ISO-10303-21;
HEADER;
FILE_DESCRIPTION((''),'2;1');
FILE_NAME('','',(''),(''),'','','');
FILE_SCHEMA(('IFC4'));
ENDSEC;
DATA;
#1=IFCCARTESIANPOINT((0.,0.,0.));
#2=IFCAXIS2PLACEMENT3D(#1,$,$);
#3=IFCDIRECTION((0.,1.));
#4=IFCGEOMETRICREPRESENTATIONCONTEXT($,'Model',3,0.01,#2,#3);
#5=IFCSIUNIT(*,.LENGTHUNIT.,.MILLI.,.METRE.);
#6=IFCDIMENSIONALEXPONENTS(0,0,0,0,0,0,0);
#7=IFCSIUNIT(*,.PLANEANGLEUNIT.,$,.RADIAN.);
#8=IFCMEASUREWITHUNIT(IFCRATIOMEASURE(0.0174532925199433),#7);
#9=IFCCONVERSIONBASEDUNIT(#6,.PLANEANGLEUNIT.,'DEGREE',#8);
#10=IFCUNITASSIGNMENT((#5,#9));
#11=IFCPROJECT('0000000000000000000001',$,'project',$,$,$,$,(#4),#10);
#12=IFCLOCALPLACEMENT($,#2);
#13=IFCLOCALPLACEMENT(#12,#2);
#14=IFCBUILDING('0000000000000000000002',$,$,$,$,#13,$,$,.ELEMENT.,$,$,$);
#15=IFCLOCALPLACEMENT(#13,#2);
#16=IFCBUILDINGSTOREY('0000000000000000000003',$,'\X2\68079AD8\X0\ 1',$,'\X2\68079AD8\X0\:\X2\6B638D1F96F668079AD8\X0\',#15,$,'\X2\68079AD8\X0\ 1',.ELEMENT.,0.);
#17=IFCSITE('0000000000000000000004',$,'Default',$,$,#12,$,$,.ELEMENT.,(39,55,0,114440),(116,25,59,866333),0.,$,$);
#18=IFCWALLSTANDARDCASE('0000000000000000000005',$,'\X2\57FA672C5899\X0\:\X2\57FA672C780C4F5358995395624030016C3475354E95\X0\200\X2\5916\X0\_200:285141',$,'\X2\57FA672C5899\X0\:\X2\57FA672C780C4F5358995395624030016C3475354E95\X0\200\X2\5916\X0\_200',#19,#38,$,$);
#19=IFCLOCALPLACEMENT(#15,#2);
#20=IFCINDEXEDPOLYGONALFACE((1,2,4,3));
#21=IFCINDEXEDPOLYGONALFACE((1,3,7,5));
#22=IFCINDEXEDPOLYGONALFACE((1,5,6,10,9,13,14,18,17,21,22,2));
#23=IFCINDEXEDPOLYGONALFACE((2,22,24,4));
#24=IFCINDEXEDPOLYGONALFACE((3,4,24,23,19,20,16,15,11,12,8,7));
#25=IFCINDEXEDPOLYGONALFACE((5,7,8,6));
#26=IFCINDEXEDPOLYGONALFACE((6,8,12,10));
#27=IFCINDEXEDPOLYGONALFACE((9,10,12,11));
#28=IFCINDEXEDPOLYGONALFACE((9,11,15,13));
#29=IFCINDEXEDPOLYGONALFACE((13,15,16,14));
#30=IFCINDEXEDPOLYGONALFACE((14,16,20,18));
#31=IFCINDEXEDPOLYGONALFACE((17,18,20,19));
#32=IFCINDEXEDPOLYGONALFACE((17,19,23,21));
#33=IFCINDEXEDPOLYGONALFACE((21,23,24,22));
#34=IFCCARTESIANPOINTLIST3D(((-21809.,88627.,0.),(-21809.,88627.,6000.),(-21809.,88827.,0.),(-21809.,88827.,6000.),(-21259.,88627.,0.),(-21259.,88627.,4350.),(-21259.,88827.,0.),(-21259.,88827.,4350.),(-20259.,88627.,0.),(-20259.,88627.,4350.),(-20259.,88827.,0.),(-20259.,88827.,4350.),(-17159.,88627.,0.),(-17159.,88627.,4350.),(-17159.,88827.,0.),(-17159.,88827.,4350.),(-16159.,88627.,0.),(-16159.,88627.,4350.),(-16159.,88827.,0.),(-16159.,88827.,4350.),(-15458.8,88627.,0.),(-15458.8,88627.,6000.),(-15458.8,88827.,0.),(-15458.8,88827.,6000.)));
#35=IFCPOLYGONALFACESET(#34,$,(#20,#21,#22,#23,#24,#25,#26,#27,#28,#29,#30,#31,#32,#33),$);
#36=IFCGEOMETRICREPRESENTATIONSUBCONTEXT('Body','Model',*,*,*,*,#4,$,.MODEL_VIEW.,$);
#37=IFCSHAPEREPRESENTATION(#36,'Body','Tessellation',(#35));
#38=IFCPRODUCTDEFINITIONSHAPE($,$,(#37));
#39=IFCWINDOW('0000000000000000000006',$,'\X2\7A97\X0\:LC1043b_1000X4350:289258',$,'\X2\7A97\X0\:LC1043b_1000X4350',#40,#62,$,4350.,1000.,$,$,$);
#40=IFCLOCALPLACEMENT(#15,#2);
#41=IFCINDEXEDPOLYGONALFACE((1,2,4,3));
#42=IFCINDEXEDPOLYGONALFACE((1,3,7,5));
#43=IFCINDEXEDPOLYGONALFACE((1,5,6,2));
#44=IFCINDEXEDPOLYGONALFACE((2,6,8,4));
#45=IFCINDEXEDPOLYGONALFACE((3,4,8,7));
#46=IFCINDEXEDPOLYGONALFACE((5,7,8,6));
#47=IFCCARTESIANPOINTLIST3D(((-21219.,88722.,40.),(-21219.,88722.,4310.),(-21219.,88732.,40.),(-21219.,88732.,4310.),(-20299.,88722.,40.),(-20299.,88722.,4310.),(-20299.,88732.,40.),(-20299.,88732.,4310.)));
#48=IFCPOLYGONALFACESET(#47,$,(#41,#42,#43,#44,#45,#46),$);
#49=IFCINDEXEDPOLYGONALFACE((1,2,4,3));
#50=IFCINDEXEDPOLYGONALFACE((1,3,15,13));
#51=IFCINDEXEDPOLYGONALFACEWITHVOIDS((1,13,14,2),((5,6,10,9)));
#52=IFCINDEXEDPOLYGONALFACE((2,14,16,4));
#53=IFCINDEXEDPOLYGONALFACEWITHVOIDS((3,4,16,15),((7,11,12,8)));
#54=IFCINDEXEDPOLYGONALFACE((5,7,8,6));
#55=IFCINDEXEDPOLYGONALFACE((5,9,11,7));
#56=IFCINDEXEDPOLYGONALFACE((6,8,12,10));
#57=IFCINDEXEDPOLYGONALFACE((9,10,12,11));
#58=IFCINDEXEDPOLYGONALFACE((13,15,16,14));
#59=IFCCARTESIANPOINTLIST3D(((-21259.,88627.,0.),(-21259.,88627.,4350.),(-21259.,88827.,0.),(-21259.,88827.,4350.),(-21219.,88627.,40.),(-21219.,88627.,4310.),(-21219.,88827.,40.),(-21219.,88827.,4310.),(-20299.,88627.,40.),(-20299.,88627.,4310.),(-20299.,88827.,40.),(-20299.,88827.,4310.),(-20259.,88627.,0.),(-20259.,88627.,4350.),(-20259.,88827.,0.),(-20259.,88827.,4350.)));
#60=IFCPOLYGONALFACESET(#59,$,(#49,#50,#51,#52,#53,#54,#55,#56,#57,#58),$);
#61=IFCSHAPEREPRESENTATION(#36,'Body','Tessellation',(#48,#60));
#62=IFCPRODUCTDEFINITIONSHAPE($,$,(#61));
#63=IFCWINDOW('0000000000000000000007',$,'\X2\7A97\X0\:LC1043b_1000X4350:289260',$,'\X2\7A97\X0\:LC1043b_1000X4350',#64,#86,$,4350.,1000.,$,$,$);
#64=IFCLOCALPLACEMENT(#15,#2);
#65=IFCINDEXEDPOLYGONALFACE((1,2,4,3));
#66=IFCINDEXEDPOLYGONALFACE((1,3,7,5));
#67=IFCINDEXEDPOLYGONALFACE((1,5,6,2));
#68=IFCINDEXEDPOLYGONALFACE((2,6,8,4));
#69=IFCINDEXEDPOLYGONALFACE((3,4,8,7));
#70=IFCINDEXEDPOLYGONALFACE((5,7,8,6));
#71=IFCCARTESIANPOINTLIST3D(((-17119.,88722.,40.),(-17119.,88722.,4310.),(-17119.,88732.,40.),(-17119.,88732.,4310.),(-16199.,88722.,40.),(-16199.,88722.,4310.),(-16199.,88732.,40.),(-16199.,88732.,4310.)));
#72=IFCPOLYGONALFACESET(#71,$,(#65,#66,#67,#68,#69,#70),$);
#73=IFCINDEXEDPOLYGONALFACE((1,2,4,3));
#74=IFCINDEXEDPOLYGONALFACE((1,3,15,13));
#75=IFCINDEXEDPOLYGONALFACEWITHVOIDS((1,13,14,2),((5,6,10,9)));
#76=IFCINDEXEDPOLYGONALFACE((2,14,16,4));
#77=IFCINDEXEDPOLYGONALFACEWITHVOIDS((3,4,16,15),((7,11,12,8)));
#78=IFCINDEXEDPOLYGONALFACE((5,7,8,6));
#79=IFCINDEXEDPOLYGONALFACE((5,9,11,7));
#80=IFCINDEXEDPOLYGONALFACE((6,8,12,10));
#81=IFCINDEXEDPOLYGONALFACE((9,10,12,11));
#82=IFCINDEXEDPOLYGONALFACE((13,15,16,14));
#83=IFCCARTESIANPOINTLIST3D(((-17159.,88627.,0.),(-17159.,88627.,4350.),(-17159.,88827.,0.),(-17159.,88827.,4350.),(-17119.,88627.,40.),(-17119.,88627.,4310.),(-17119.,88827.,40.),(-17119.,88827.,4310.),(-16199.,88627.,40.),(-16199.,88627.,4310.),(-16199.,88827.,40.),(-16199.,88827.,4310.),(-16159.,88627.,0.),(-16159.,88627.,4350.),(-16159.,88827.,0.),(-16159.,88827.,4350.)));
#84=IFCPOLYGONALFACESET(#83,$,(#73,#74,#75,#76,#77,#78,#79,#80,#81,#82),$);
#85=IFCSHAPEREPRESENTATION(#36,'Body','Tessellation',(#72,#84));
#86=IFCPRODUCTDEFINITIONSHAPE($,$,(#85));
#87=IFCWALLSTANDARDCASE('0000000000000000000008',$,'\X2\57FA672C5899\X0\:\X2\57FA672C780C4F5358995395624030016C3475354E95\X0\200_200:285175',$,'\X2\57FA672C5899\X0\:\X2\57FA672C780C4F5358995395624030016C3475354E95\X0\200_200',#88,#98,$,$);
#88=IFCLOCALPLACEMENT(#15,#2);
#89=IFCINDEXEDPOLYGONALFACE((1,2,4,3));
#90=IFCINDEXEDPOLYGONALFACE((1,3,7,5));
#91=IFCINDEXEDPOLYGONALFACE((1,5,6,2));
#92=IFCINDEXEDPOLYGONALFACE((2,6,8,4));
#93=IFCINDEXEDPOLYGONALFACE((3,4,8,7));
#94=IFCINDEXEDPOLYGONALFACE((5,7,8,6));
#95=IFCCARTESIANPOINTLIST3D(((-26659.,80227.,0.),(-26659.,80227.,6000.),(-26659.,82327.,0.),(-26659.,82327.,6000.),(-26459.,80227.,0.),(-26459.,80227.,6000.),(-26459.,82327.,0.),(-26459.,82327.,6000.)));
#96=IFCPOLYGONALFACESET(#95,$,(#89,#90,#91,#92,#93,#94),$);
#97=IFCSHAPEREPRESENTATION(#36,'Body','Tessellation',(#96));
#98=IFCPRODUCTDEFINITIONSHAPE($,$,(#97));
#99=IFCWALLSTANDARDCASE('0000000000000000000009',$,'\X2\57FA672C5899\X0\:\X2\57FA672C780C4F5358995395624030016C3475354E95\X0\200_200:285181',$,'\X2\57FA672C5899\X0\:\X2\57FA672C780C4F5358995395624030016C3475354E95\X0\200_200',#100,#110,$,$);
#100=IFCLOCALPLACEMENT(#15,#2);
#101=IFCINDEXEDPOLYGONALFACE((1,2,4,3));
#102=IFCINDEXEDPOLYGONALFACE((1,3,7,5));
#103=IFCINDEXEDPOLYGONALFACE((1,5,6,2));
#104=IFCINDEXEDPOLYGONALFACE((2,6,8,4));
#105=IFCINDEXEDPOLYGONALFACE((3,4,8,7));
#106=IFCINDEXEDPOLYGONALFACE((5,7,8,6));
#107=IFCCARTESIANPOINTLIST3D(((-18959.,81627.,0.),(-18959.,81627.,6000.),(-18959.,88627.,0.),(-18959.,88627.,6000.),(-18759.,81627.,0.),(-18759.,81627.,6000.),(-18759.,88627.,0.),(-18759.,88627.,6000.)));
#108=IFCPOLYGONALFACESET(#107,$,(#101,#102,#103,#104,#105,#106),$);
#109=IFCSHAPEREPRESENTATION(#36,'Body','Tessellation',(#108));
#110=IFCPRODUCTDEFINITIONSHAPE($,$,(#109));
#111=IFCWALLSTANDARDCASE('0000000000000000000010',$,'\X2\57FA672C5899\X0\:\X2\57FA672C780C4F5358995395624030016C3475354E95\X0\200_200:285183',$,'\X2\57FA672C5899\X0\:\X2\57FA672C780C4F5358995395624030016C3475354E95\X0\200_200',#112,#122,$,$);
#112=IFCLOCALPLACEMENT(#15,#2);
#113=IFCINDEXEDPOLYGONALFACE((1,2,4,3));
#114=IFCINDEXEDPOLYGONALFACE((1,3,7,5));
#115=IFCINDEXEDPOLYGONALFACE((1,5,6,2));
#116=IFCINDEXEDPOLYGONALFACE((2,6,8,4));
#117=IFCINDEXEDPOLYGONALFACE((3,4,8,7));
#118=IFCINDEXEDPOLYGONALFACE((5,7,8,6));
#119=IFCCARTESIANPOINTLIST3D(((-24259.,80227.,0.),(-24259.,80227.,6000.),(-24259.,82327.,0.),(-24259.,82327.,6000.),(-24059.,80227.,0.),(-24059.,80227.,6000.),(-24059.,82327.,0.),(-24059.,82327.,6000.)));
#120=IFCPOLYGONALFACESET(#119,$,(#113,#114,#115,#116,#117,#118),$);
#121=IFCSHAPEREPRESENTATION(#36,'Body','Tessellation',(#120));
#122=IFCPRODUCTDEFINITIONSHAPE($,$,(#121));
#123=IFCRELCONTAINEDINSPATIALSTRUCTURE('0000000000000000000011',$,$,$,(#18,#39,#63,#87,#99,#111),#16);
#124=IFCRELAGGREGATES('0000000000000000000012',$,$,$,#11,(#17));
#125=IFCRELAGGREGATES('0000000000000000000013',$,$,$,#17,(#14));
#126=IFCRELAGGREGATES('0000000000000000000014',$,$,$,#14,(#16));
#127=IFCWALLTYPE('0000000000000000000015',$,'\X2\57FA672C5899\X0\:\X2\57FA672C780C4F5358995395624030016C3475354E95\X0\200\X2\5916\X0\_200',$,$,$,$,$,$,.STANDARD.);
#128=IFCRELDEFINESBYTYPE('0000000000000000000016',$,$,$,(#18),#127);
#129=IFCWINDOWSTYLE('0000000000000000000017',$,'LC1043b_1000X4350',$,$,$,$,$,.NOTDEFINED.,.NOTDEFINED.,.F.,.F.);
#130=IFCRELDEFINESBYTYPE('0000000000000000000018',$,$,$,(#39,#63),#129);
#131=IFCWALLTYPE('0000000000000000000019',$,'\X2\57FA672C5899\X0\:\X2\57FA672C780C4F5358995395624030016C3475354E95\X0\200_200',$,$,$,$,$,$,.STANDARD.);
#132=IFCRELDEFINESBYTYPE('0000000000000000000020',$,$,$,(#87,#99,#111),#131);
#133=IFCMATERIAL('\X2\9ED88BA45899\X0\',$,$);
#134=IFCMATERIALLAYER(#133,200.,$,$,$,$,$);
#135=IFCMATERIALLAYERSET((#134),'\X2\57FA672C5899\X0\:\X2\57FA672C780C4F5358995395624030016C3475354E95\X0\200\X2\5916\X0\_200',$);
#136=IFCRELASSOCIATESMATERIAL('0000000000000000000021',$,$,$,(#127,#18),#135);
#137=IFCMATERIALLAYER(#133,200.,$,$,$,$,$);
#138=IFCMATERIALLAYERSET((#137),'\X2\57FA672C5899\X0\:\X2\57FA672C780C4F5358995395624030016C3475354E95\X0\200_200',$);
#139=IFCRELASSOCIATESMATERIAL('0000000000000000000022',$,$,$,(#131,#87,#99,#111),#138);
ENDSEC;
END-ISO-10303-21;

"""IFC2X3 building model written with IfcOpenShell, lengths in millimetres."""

from ifc_helpers import new_model, entity, si_unit, converted_unit, direction, frame, frame_2d, origin, origin_2d_with_axis, place, context, subcontext, project, spatial, polyline, rectangle, outline, extrude, source, transform, mapped, material, layer, layer_set, layer_usage, type_object, type_shapes, element, fill, save


model = new_model("IFC2X3")

# Units and contexts
model_context = context("Model", 3, precision=0.01, world=origin(), true_north=direction((0.0, 1.0)))
body_context = subcontext(model_context, "Body", "Model", "MODEL_VIEW")
ifc_project = project(units=[si_unit("LENGTHUNIT", "METRE", prefix="MILLI"), converted_unit("PLANEANGLEUNIT", "DEGREE", entity("IfcRatioMeasure", 0.0174532925199433), si_unit("PLANEANGLEUNIT", "RADIAN"), dimensions=[0, 0, 0, 0, 0, 0, 0])], contexts=[model_context])

# Site, building, storey
site_placement = place(None, origin())
site = spatial("IfcSite", under=ifc_project, at=site_placement, Name="Default", CompositionType="ELEMENT", RefLatitude=(39, 55, 0, 114440), RefLongitude=(116, 25, 59, 866333), RefElevation=0.0)
building_placement = place(site_placement, origin())
building = spatial("IfcBuilding", under=site, at=building_placement, CompositionType="ELEMENT")
storey_placement = place(building_placement, origin())
storey = spatial("IfcBuildingStorey", under=building, at=storey_placement, Name="标高 1", ObjectType="标高:正负零标高", LongName="标高 1", CompositionType="ELEMENT", Elevation=0.0)

# Shared definitions
ifc_material = material(Name="默认墙")

# Wall, openings, windows
ifc_layer_1 = layer(ifc_material, 200.0)
ifc_layer_set_1 = layer_set([ifc_layer_1], Name="基本墙:基本砌体墙厕所、水电井200外_200")
ifc_layer_usage_1 = layer_usage(ifc_layer_set_1, "AXIS2", "NEGATIVE", 100.0)
wall_type_1 = type_object("IfcWallType", Name="基本墙:基本砌体墙厕所、水电井200外_200", PredefinedType="STANDARD", material=ifc_layer_set_1)
wall_1_placement = place(building_placement, frame((-21809.0, 88727.0, 0.0)))
wall_1 = element("IfcWallStandardCase", 1, at=wall_1_placement, inside=storey, type_object=wall_type_1, material=ifc_layer_usage_1, Name="基本墙:基本砌体墙厕所、水电井200外_200:285141", ObjectType="基本墙:基本砌体墙厕所、水电井200外_200", context=body_context, shape_type="SweptSolid", body=[
    extrude(rectangle(XDim=6350.2, YDim=200.0, at=frame_2d((3175.1, 0.0), x_axis=(-1.0, 0.0))), origin(), (0.0, 0.0, 1.0), 6000.0),
])
opening_1_placement = place(wall_1_placement, frame((550.0, -100.0, 0.0)))
opening_1 = element("IfcOpeningElement", 2, at=opening_1_placement, cuts=wall_1, ObjectType="Opening", context=body_context, shape_type="SweptSolid", body=[
    extrude(rectangle(XDim=4350.0, YDim=1000.0, at=frame_2d((2175.0, 500.0), x_axis=(1.0, 0.0))), frame((0.0, 0.0, 0.0), z_axis=(0.0, 1.0, 0.0), x_axis=(0.0, 0.0, 1.0)), (0.0, 0.0, 1.0), 200.0),
])
opening_2_placement = place(wall_1_placement, frame((4650.0, -100.0, 0.0)))
opening_2 = element("IfcOpeningElement", 3, at=opening_2_placement, cuts=wall_1, ObjectType="Opening", context=body_context, shape_type="SweptSolid", body=[
    extrude(rectangle(XDim=4350.0, YDim=1000.0, at=frame_2d((2175.0, 500.0), x_axis=(1.0, 0.0))), frame((0.0, 0.0, 0.0), z_axis=(0.0, 1.0, 0.0), x_axis=(0.0, 0.0, 1.0)), (0.0, 0.0, 1.0), 200.0),
])
window_style = type_object("IfcWindowStyle", Name="LC1043b_1000X4350", ConstructionType="NOTDEFINED", OperationType="NOTDEFINED", ParameterTakesPrecedence=False, Sizeable=False)
shared_shape_1 = source(origin(), body_context, "Body", "SweptSolid", [
    extrude(rectangle(XDim=10.0, YDim=920.0, at=origin_2d_with_axis()), frame((500.0, -800.0, 40.0), z_axis=(0.0, 0.0, 1.0), x_axis=(0.0, 1.0, 0.0)), (0.0, 0.0, 1.0), 4270.0),
    extrude(outline(polyline([(-500.0, -2175.0), (500.0, -2175.0), (500.0, 2175.0), (-500.0, 2175.0), (-500.0, -2175.0)]), holes=[polyline([(460.0, 2135.0), (460.0, -2135.0), (-460.0, -2135.0), (-460.0, 2135.0), (460.0, 2135.0)])]), frame((500.0, -900.0, 2175.0), z_axis=(0.0, 1.0, 0.0), x_axis=(-1.0, 0.0, 0.0)), (0.0, 0.0, 1.0), 200.0),
])
type_shapes(window_style, [shared_shape_1])
window_1_placement = place(opening_1_placement, frame((0.0, 900.0, 0.0)))
window_1 = element("IfcWindow", 4, at=window_1_placement, inside=storey, type_object=window_style, Name="窗:LC1043b_1000X4350:289258", ObjectType="窗:LC1043b_1000X4350", OverallHeight=4350.0, OverallWidth=1000.0, context=body_context, shape_type="MappedRepresentation", body=[
    mapped(shared_shape_1, transform((0.0, 0.0, 0.0), scale=1.0)),
])
fill(opening_1, window_1)
window_2_placement = place(opening_2_placement, frame((0.0, 900.0, 0.0)))
window_2 = element("IfcWindow", 5, at=window_2_placement, inside=storey, type_object=window_style, Name="窗:LC1043b_1000X4350:289260", ObjectType="窗:LC1043b_1000X4350", OverallHeight=4350.0, OverallWidth=1000.0, context=body_context, shape_type="MappedRepresentation", body=[
    mapped(shared_shape_1, transform((0.0, 0.0, 0.0), scale=1.0)),
])
fill(opening_2, window_2)

# Walls
ifc_layer_2 = layer(ifc_material, 200.0)
ifc_layer_set_2 = layer_set([ifc_layer_2], Name="基本墙:基本砌体墙厕所、水电井200_200")
ifc_layer_usage_2 = layer_usage(ifc_layer_set_2, "AXIS2", "NEGATIVE", 100.0)
wall_type_2 = type_object("IfcWallType", Name="基本墙:基本砌体墙厕所、水电井200_200", PredefinedType="STANDARD", material=ifc_layer_set_2)
wall_2_placement = place(building_placement, frame((-26559.0, 82327.0, 0.0), z_axis=(0.0, 0.0, 1.0), x_axis=(0.0, -1.0, 0.0)))
element("IfcWallStandardCase", 6, at=wall_2_placement, inside=storey, type_object=wall_type_2, material=ifc_layer_usage_2, Name="基本墙:基本砌体墙厕所、水电井200_200:285175", ObjectType="基本墙:基本砌体墙厕所、水电井200_200", context=body_context, shape_type="SweptSolid", body=[
    extrude(rectangle(XDim=2100.0, YDim=200.0, at=frame_2d((1050.0, 0.0), x_axis=(-1.0, 0.0))), origin(), (0.0, 0.0, 1.0), 6000.0),
])
ifc_layer_usage_3 = layer_usage(ifc_layer_set_2, "AXIS2", "NEGATIVE", 100.0)
wall_3_placement = place(building_placement, frame((-18859.0, 81627.0, 0.0), z_axis=(0.0, 0.0, 1.0), x_axis=(0.0, 1.0, 0.0)))
element("IfcWallStandardCase", 7, at=wall_3_placement, inside=storey, type_object=wall_type_2, material=ifc_layer_usage_3, Name="基本墙:基本砌体墙厕所、水电井200_200:285181", ObjectType="基本墙:基本砌体墙厕所、水电井200_200", context=body_context, shape_type="SweptSolid", body=[
    extrude(rectangle(XDim=7000.0, YDim=200.0, at=frame_2d((3500.0, 0.0), x_axis=(-1.0, 0.0))), origin(), (0.0, 0.0, 1.0), 6000.0),
])
ifc_layer_usage_4 = layer_usage(ifc_layer_set_2, "AXIS2", "NEGATIVE", 100.0)
wall_4_placement = place(building_placement, frame((-24159.0, 82327.0, 0.0), z_axis=(0.0, 0.0, 1.0), x_axis=(0.0, -1.0, 0.0)))
element("IfcWallStandardCase", 8, at=wall_4_placement, inside=storey, type_object=wall_type_2, material=ifc_layer_usage_4, Name="基本墙:基本砌体墙厕所、水电井200_200:285183", ObjectType="基本墙:基本砌体墙厕所、水电井200_200", context=body_context, shape_type="SweptSolid", body=[
    extrude(rectangle(XDim=2100.0, YDim=200.0, at=frame_2d((1050.0, 0.0), x_axis=(-1.0, 0.0))), origin(), (0.0, 0.0, 1.0), 6000.0),
])

save(model, "model.ifc")
